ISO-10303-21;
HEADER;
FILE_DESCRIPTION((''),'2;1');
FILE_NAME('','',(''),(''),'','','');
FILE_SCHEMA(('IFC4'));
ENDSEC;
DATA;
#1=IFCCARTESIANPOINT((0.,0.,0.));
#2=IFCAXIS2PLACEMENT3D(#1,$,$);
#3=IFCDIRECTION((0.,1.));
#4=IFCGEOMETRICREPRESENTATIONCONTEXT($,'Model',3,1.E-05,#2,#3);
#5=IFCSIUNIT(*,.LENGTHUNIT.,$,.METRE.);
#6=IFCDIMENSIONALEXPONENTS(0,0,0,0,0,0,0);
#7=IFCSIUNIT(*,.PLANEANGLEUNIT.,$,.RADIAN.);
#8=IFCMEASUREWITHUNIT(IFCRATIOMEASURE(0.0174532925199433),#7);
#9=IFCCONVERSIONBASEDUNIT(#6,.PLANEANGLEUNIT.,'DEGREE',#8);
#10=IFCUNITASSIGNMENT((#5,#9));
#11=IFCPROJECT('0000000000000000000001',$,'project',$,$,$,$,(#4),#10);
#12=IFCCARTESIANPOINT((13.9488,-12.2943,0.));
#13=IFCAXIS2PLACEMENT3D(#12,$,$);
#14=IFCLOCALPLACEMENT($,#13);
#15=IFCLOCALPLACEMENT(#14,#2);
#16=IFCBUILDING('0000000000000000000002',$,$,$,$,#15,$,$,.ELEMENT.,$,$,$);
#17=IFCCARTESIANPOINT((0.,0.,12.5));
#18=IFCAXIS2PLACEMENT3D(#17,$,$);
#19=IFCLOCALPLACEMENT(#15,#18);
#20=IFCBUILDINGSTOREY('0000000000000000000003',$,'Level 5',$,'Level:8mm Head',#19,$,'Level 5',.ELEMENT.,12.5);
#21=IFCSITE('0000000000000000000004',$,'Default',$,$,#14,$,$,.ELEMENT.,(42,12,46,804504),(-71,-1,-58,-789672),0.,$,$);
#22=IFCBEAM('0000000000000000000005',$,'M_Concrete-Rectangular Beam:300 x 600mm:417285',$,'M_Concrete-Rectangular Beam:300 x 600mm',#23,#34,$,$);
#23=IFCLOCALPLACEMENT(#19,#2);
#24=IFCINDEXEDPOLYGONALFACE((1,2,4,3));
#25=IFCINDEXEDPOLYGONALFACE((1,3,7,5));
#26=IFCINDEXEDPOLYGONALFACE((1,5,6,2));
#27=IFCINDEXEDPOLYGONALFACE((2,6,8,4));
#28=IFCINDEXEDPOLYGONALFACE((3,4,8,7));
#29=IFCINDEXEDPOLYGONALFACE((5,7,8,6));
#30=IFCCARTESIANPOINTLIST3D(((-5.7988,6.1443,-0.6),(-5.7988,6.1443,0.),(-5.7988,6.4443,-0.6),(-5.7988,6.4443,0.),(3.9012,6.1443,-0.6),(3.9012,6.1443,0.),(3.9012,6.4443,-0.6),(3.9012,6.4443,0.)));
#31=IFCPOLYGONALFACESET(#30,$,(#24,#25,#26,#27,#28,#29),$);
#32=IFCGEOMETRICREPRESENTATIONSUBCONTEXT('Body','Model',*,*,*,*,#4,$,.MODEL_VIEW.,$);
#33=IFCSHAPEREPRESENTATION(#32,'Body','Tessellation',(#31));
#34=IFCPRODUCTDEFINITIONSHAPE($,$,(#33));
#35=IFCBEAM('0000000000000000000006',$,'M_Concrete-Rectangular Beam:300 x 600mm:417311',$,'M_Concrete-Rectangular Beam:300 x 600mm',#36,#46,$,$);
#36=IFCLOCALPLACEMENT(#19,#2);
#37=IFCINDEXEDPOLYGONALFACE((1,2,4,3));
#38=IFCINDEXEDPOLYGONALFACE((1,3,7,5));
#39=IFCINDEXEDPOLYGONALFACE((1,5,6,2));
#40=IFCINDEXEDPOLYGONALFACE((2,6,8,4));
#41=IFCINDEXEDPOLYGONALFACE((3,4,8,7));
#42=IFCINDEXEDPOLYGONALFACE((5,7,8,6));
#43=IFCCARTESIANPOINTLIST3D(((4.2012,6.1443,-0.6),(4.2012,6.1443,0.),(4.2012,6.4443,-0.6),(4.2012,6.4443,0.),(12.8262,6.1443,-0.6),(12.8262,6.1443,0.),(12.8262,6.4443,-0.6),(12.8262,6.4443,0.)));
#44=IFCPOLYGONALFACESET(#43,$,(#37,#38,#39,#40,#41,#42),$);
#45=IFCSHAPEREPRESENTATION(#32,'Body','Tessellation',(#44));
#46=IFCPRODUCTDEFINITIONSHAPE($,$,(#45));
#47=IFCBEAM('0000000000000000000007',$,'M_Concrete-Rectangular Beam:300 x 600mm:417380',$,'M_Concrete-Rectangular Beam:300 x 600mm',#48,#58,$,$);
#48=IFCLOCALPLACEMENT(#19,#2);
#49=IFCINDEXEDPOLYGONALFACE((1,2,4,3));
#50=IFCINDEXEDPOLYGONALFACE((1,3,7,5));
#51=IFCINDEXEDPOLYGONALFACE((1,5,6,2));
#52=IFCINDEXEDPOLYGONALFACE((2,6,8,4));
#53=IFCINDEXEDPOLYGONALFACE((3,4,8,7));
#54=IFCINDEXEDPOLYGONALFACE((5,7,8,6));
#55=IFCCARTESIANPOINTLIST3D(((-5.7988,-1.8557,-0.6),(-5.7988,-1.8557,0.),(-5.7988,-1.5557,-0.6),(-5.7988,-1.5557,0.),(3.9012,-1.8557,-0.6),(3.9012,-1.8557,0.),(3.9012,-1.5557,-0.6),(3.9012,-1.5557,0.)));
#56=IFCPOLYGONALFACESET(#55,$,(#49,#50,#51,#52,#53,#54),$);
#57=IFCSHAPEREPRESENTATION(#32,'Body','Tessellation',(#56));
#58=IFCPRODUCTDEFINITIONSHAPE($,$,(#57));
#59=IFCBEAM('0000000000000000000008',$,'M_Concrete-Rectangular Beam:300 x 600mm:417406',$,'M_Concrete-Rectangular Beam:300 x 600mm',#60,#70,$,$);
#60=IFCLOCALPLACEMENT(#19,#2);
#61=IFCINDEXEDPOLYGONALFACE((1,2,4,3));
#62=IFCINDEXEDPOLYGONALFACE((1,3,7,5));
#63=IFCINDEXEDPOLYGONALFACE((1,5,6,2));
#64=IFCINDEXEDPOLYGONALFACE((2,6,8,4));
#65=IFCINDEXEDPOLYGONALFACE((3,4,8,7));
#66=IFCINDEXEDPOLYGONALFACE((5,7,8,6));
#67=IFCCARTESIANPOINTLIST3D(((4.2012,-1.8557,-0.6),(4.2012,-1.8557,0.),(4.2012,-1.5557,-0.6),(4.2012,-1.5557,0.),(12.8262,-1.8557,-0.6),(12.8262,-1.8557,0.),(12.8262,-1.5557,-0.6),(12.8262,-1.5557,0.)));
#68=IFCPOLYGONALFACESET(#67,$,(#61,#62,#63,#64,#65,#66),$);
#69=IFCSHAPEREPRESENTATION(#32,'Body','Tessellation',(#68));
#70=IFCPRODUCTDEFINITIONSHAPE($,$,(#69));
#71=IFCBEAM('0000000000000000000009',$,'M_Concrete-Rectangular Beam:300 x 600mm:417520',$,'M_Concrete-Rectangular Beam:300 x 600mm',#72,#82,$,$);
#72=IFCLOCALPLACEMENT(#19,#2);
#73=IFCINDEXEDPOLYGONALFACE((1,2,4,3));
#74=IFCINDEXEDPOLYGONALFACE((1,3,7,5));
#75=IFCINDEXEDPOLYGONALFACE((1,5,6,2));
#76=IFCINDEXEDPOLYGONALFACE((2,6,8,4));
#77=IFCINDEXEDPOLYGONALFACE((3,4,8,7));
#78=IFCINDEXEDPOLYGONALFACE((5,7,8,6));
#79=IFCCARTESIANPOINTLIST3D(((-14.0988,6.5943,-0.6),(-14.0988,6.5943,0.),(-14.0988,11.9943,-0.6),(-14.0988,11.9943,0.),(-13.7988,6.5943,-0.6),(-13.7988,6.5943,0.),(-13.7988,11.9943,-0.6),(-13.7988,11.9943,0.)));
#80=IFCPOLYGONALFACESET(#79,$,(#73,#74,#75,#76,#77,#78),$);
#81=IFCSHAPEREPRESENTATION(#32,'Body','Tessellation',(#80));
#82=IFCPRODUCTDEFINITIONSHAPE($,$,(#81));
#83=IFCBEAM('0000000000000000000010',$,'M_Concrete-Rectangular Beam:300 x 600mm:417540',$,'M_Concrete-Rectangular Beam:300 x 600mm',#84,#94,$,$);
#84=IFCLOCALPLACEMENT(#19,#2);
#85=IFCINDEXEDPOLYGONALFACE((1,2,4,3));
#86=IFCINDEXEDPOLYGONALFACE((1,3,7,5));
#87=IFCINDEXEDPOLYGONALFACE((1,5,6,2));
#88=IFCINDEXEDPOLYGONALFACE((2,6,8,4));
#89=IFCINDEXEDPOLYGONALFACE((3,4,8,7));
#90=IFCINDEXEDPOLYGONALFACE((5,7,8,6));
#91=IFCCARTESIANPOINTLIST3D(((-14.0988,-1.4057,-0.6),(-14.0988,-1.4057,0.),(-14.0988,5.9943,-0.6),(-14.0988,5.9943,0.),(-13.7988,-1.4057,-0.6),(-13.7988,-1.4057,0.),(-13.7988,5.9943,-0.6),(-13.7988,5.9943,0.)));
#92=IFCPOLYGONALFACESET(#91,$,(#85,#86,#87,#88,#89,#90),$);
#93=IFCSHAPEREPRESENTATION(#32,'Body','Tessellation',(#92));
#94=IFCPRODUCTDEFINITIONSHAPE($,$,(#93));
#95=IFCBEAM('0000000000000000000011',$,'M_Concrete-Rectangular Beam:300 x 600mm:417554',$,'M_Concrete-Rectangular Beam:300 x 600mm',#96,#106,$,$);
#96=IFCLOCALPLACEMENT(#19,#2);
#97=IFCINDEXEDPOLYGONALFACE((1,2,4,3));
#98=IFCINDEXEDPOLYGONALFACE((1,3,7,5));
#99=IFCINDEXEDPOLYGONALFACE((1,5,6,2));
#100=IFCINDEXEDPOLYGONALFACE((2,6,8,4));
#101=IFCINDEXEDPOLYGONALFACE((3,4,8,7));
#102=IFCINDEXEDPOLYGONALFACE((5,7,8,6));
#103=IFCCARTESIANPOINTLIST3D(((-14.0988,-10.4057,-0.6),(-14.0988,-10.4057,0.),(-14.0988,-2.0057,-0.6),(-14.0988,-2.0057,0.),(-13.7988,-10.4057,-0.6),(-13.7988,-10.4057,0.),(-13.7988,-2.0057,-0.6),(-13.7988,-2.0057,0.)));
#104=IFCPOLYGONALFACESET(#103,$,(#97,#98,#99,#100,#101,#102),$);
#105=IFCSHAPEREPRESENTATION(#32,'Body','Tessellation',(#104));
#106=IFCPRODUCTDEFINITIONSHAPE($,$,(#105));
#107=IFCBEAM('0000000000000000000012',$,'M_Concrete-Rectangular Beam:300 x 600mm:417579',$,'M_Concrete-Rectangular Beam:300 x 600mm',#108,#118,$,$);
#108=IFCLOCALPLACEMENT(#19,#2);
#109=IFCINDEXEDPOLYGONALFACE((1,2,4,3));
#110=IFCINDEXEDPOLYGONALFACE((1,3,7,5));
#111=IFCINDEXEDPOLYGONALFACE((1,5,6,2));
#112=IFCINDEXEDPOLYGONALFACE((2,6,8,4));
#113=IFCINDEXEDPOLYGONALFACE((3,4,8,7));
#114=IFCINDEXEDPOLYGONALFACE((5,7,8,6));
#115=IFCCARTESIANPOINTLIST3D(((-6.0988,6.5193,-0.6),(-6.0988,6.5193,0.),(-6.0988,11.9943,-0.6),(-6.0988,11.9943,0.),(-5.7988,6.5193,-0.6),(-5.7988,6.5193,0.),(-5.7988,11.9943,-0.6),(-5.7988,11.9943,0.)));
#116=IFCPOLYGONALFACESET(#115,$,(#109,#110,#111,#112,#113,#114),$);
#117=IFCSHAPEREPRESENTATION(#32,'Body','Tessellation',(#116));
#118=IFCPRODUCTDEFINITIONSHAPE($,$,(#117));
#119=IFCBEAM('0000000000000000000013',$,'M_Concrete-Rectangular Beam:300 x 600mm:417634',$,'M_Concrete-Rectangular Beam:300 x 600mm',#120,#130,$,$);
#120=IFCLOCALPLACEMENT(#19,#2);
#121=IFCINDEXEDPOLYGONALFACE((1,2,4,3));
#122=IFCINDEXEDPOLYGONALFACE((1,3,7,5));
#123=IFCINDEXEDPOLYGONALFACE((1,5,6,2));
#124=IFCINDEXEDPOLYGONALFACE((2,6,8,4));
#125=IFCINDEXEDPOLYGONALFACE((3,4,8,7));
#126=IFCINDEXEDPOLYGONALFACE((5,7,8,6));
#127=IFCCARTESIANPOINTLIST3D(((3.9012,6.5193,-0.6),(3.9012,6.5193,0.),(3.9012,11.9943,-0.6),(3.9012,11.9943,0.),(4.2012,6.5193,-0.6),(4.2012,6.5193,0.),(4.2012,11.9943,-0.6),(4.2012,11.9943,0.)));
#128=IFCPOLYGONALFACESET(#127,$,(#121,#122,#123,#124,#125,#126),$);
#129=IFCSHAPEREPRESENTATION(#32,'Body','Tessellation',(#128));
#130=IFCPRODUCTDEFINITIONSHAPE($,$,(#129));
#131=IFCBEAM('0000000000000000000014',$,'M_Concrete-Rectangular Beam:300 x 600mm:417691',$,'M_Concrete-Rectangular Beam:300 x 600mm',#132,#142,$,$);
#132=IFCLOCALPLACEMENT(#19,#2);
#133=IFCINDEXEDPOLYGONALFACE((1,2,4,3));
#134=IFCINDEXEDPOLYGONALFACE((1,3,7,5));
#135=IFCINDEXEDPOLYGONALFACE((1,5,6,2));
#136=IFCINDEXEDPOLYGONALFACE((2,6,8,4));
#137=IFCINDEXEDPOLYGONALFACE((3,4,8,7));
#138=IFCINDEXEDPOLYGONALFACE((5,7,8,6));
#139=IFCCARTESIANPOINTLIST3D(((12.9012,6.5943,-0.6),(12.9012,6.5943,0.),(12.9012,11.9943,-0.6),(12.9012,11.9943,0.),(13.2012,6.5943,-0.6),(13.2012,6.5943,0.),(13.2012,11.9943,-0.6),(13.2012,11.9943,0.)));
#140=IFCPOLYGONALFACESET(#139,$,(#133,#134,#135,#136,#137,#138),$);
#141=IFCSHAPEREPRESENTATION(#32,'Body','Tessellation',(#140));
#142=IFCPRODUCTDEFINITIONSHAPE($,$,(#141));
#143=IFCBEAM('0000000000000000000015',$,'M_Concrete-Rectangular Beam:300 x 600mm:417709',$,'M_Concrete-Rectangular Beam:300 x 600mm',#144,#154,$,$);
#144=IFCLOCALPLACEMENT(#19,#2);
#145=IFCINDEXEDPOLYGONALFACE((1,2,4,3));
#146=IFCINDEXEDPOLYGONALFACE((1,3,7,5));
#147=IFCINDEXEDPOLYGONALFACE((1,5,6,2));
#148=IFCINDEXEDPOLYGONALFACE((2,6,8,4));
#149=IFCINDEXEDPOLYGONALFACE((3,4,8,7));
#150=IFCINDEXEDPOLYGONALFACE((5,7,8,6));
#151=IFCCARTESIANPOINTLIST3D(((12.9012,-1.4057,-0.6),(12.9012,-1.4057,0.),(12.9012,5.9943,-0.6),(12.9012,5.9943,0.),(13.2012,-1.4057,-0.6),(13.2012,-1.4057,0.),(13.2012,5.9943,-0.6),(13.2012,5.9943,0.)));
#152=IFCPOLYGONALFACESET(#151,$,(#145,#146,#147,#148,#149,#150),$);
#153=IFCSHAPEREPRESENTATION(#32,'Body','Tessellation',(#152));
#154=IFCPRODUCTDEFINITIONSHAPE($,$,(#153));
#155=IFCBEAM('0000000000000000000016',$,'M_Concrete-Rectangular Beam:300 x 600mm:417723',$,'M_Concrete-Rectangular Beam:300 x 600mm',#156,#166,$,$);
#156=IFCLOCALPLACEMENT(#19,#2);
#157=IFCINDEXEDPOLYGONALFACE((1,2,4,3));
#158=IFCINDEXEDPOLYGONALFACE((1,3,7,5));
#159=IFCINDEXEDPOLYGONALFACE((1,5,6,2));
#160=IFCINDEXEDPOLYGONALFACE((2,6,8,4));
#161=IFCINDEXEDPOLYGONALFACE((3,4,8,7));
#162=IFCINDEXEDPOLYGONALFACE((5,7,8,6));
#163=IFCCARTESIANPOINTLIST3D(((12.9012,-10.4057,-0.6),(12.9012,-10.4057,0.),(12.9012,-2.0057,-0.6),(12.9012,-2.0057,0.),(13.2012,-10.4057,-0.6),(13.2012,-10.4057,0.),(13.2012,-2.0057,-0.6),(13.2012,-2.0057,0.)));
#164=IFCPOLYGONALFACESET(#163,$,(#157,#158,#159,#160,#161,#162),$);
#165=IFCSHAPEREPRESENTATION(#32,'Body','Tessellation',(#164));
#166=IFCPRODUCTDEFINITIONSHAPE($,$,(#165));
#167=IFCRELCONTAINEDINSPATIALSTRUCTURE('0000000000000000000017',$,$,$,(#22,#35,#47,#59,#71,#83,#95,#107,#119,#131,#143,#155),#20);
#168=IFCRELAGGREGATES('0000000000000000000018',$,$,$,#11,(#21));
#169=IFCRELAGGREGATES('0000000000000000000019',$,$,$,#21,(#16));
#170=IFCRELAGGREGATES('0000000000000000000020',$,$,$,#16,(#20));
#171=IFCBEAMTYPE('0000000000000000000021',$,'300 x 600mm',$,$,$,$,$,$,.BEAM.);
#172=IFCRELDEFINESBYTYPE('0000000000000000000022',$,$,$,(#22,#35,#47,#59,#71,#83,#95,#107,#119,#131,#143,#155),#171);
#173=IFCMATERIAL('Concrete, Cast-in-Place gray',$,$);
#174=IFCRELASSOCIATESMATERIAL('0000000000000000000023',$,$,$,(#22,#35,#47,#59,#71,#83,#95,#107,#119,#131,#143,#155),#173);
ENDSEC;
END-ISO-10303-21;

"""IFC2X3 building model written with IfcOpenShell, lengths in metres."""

from ifc_helpers import new_model, entity, si_unit, converted_unit, direction, frame, frame_2d, origin, place, context, subcontext, project, spatial, rectangle, extrude, material, type_object, element, save


model = new_model("IFC2X3")

# Units and contexts
model_context = context("Model", 3, precision=1e-05, world=origin(), true_north=direction((0.0, 1.0)))
body_context = subcontext(model_context, "Body", "Model", "MODEL_VIEW")
ifc_project = project(units=[si_unit("LENGTHUNIT", "METRE"), converted_unit("PLANEANGLEUNIT", "DEGREE", entity("IfcRatioMeasure", 0.0174532925199433), si_unit("PLANEANGLEUNIT", "RADIAN"), dimensions=[0, 0, 0, 0, 0, 0, 0])], contexts=[model_context])

# Site, building, storey
site_placement = place(None, frame((13.9488, -12.2943, 0.0)))
site = spatial("IfcSite", under=ifc_project, at=site_placement, Name="Default", CompositionType="ELEMENT", RefLatitude=(42, 12, 46, 804504), RefLongitude=(-71, -1, -58, -789672), RefElevation=0.0)
building_placement = place(site_placement, origin())
building = spatial("IfcBuilding", under=site, at=building_placement, CompositionType="ELEMENT")
storey_placement = place(building_placement, frame((0.0, 0.0, 12.5)))
storey = spatial("IfcBuildingStorey", under=building, at=storey_placement, Name="Level 5", ObjectType="Level:8mm Head", LongName="Level 5", CompositionType="ELEMENT", Elevation=12.5)

# Beams
ifc_material = material(Name="Concrete, Cast-in-Place gray")
beam_type = type_object("IfcBeamType", Name="300 x 600mm", PredefinedType="BEAM")
beam_1_placement = place(storey_placement, frame((-5.9488, 6.2943, 0.0)))
element("IfcBeam", 1, at=beam_1_placement, inside=storey, type_object=beam_type, material=ifc_material, Name="M_Concrete-Rectangular Beam:300 x 600mm:417285", ObjectType="M_Concrete-Rectangular Beam:300 x 600mm", context=body_context, shape_type="SweptSolid", body=[
    extrude(rectangle(XDim=0.6, YDim=0.3, at=frame_2d((0.0, 0.0), x_axis=(1.0, 0.0))), frame((0.15, 0.0, -0.3), z_axis=(1.0, 0.0, 0.0), x_axis=(0.0, 0.0, -1.0)), (0.0, 0.0, 1.0), 9.7),
])
beam_2_placement = place(storey_placement, frame((4.0512, 6.2943, 0.0)))
element("IfcBeam", 2, at=beam_2_placement, inside=storey, type_object=beam_type, material=ifc_material, Name="M_Concrete-Rectangular Beam:300 x 600mm:417311", ObjectType="M_Concrete-Rectangular Beam:300 x 600mm", context=body_context, shape_type="SweptSolid", body=[
    extrude(rectangle(XDim=0.6, YDim=0.3, at=frame_2d((0.0, 0.0), x_axis=(1.0, 0.0))), frame((0.15, 0.0, -0.3), z_axis=(1.0, 0.0, 0.0), x_axis=(0.0, 0.0, -1.0)), (0.0, 0.0, 1.0), 8.625),
])
beam_3_placement = place(storey_placement, frame((-5.9488, -1.7057, 0.0)))
element("IfcBeam", 3, at=beam_3_placement, inside=storey, type_object=beam_type, material=ifc_material, Name="M_Concrete-Rectangular Beam:300 x 600mm:417380", ObjectType="M_Concrete-Rectangular Beam:300 x 600mm", context=body_context, shape_type="SweptSolid", body=[
    extrude(rectangle(XDim=0.6, YDim=0.3, at=frame_2d((0.0, 0.0), x_axis=(1.0, 0.0))), frame((0.15, 0.0, -0.3), z_axis=(1.0, 0.0, 0.0), x_axis=(0.0, 0.0, -1.0)), (0.0, 0.0, 1.0), 9.7),
])
beam_4_placement = place(storey_placement, frame((4.0512, -1.7057, 0.0)))
element("IfcBeam", 4, at=beam_4_placement, inside=storey, type_object=beam_type, material=ifc_material, Name="M_Concrete-Rectangular Beam:300 x 600mm:417406", ObjectType="M_Concrete-Rectangular Beam:300 x 600mm", context=body_context, shape_type="SweptSolid", body=[
    extrude(rectangle(XDim=0.6, YDim=0.3, at=frame_2d((0.0, 0.0), x_axis=(1.0, 0.0))), frame((0.15, 0.0, -0.3), z_axis=(1.0, 0.0, 0.0), x_axis=(0.0, 0.0, -1.0)), (0.0, 0.0, 1.0), 8.625),
])
beam_5_placement = place(storey_placement, frame((-13.9488, 12.2943, 0.0), z_axis=(0.0, 0.0, 1.0), x_axis=(0.0, -1.0, 0.0)))
element("IfcBeam", 5, at=beam_5_placement, inside=storey, type_object=beam_type, material=ifc_material, Name="M_Concrete-Rectangular Beam:300 x 600mm:417520", ObjectType="M_Concrete-Rectangular Beam:300 x 600mm", context=body_context, shape_type="SweptSolid", body=[
    extrude(rectangle(XDim=0.6, YDim=0.3, at=frame_2d((0.0, 0.0), x_axis=(1.0, 0.0))), frame((0.3, 0.0, -0.3), z_axis=(1.0, 0.0, 0.0), x_axis=(0.0, 0.0, -1.0)), (0.0, 0.0, 1.0), 5.4),
])
beam_6_placement = place(storey_placement, frame((-13.9488, 6.2943, 0.0), z_axis=(0.0, 0.0, 1.0), x_axis=(0.0, -1.0, 0.0)))
element("IfcBeam", 6, at=beam_6_placement, inside=storey, type_object=beam_type, material=ifc_material, Name="M_Concrete-Rectangular Beam:300 x 600mm:417540", ObjectType="M_Concrete-Rectangular Beam:300 x 600mm", context=body_context, shape_type="SweptSolid", body=[
    extrude(rectangle(XDim=0.6, YDim=0.3, at=frame_2d((0.0, 0.0), x_axis=(1.0, 0.0))), frame((0.3, 0.0, -0.3), z_axis=(1.0, 0.0, 0.0), x_axis=(0.0, 0.0, -1.0)), (0.0, 0.0, 1.0), 7.4),
])
beam_7_placement = place(storey_placement, frame((-13.9488, -1.7057, 0.0), z_axis=(0.0, 0.0, 1.0), x_axis=(0.0, -1.0, 0.0)))
element("IfcBeam", 7, at=beam_7_placement, inside=storey, type_object=beam_type, material=ifc_material, Name="M_Concrete-Rectangular Beam:300 x 600mm:417554", ObjectType="M_Concrete-Rectangular Beam:300 x 600mm", context=body_context, shape_type="SweptSolid", body=[
    extrude(rectangle(XDim=0.6, YDim=0.3, at=frame_2d((0.0, 0.0), x_axis=(1.0, 0.0))), frame((0.3, 0.0, -0.3), z_axis=(1.0, 0.0, 0.0), x_axis=(0.0, 0.0, -1.0)), (0.0, 0.0, 1.0), 8.4),
])
beam_8_placement = place(storey_placement, frame((-5.9488, 12.2943, 0.0), z_axis=(0.0, 0.0, 1.0), x_axis=(0.0, -1.0, 0.0)))
element("IfcBeam", 8, at=beam_8_placement, inside=storey, type_object=beam_type, material=ifc_material, Name="M_Concrete-Rectangular Beam:300 x 600mm:417579", ObjectType="M_Concrete-Rectangular Beam:300 x 600mm", context=body_context, shape_type="SweptSolid", body=[
    extrude(rectangle(XDim=0.6, YDim=0.3, at=frame_2d((0.0, 0.0), x_axis=(1.0, 0.0))), frame((0.3, 0.0, -0.3), z_axis=(1.0, 0.0, 0.0), x_axis=(0.0, 0.0, -1.0)), (0.0, 0.0, 1.0), 5.475),
])
beam_9_placement = place(storey_placement, frame((4.0512, 12.2943, 0.0), z_axis=(0.0, 0.0, 1.0), x_axis=(0.0, -1.0, 0.0)))
element("IfcBeam", 9, at=beam_9_placement, inside=storey, type_object=beam_type, material=ifc_material, Name="M_Concrete-Rectangular Beam:300 x 600mm:417634", ObjectType="M_Concrete-Rectangular Beam:300 x 600mm", context=body_context, shape_type="SweptSolid", body=[
    extrude(rectangle(XDim=0.6, YDim=0.3, at=frame_2d((0.0, 0.0), x_axis=(1.0, 0.0))), frame((0.3, 0.0, -0.3), z_axis=(1.0, 0.0, 0.0), x_axis=(0.0, 0.0, -1.0)), (0.0, 0.0, 1.0), 5.475),
])
beam_10_placement = place(storey_placement, frame((13.0512, 12.2943, 0.0), z_axis=(0.0, 0.0, 1.0), x_axis=(0.0, -1.0, 0.0)))
element("IfcBeam", 10, at=beam_10_placement, inside=storey, type_object=beam_type, material=ifc_material, Name="M_Concrete-Rectangular Beam:300 x 600mm:417691", ObjectType="M_Concrete-Rectangular Beam:300 x 600mm", context=body_context, shape_type="SweptSolid", body=[
    extrude(rectangle(XDim=0.6, YDim=0.3, at=frame_2d((0.0, 0.0), x_axis=(1.0, 0.0))), frame((0.3, 0.0, -0.3), z_axis=(1.0, 0.0, 0.0), x_axis=(0.0, 0.0, -1.0)), (0.0, 0.0, 1.0), 5.4),
])
beam_11_placement = place(storey_placement, frame((13.0512, 6.2943, 0.0), z_axis=(0.0, 0.0, 1.0), x_axis=(0.0, -1.0, 0.0)))
element("IfcBeam", 11, at=beam_11_placement, inside=storey, type_object=beam_type, material=ifc_material, Name="M_Concrete-Rectangular Beam:300 x 600mm:417709", ObjectType="M_Concrete-Rectangular Beam:300 x 600mm", context=body_context, shape_type="SweptSolid", body=[
    extrude(rectangle(XDim=0.6, YDim=0.3, at=frame_2d((0.0, 0.0), x_axis=(1.0, 0.0))), frame((0.3, 0.0, -0.3), z_axis=(1.0, 0.0, 0.0), x_axis=(0.0, 0.0, -1.0)), (0.0, 0.0, 1.0), 7.4),
])
beam_12_placement = place(storey_placement, frame((13.0512, -1.7057, 0.0), z_axis=(0.0, 0.0, 1.0), x_axis=(0.0, -1.0, 0.0)))
element("IfcBeam", 12, at=beam_12_placement, inside=storey, type_object=beam_type, material=ifc_material, Name="M_Concrete-Rectangular Beam:300 x 600mm:417723", ObjectType="M_Concrete-Rectangular Beam:300 x 600mm", context=body_context, shape_type="SweptSolid", body=[
    extrude(rectangle(XDim=0.6, YDim=0.3, at=frame_2d((0.0, 0.0), x_axis=(1.0, 0.0))), frame((0.3, 0.0, -0.3), z_axis=(1.0, 0.0, 0.0), x_axis=(0.0, 0.0, -1.0)), (0.0, 0.0, 1.0), 8.4),
])

save(model, "model.ifc")
